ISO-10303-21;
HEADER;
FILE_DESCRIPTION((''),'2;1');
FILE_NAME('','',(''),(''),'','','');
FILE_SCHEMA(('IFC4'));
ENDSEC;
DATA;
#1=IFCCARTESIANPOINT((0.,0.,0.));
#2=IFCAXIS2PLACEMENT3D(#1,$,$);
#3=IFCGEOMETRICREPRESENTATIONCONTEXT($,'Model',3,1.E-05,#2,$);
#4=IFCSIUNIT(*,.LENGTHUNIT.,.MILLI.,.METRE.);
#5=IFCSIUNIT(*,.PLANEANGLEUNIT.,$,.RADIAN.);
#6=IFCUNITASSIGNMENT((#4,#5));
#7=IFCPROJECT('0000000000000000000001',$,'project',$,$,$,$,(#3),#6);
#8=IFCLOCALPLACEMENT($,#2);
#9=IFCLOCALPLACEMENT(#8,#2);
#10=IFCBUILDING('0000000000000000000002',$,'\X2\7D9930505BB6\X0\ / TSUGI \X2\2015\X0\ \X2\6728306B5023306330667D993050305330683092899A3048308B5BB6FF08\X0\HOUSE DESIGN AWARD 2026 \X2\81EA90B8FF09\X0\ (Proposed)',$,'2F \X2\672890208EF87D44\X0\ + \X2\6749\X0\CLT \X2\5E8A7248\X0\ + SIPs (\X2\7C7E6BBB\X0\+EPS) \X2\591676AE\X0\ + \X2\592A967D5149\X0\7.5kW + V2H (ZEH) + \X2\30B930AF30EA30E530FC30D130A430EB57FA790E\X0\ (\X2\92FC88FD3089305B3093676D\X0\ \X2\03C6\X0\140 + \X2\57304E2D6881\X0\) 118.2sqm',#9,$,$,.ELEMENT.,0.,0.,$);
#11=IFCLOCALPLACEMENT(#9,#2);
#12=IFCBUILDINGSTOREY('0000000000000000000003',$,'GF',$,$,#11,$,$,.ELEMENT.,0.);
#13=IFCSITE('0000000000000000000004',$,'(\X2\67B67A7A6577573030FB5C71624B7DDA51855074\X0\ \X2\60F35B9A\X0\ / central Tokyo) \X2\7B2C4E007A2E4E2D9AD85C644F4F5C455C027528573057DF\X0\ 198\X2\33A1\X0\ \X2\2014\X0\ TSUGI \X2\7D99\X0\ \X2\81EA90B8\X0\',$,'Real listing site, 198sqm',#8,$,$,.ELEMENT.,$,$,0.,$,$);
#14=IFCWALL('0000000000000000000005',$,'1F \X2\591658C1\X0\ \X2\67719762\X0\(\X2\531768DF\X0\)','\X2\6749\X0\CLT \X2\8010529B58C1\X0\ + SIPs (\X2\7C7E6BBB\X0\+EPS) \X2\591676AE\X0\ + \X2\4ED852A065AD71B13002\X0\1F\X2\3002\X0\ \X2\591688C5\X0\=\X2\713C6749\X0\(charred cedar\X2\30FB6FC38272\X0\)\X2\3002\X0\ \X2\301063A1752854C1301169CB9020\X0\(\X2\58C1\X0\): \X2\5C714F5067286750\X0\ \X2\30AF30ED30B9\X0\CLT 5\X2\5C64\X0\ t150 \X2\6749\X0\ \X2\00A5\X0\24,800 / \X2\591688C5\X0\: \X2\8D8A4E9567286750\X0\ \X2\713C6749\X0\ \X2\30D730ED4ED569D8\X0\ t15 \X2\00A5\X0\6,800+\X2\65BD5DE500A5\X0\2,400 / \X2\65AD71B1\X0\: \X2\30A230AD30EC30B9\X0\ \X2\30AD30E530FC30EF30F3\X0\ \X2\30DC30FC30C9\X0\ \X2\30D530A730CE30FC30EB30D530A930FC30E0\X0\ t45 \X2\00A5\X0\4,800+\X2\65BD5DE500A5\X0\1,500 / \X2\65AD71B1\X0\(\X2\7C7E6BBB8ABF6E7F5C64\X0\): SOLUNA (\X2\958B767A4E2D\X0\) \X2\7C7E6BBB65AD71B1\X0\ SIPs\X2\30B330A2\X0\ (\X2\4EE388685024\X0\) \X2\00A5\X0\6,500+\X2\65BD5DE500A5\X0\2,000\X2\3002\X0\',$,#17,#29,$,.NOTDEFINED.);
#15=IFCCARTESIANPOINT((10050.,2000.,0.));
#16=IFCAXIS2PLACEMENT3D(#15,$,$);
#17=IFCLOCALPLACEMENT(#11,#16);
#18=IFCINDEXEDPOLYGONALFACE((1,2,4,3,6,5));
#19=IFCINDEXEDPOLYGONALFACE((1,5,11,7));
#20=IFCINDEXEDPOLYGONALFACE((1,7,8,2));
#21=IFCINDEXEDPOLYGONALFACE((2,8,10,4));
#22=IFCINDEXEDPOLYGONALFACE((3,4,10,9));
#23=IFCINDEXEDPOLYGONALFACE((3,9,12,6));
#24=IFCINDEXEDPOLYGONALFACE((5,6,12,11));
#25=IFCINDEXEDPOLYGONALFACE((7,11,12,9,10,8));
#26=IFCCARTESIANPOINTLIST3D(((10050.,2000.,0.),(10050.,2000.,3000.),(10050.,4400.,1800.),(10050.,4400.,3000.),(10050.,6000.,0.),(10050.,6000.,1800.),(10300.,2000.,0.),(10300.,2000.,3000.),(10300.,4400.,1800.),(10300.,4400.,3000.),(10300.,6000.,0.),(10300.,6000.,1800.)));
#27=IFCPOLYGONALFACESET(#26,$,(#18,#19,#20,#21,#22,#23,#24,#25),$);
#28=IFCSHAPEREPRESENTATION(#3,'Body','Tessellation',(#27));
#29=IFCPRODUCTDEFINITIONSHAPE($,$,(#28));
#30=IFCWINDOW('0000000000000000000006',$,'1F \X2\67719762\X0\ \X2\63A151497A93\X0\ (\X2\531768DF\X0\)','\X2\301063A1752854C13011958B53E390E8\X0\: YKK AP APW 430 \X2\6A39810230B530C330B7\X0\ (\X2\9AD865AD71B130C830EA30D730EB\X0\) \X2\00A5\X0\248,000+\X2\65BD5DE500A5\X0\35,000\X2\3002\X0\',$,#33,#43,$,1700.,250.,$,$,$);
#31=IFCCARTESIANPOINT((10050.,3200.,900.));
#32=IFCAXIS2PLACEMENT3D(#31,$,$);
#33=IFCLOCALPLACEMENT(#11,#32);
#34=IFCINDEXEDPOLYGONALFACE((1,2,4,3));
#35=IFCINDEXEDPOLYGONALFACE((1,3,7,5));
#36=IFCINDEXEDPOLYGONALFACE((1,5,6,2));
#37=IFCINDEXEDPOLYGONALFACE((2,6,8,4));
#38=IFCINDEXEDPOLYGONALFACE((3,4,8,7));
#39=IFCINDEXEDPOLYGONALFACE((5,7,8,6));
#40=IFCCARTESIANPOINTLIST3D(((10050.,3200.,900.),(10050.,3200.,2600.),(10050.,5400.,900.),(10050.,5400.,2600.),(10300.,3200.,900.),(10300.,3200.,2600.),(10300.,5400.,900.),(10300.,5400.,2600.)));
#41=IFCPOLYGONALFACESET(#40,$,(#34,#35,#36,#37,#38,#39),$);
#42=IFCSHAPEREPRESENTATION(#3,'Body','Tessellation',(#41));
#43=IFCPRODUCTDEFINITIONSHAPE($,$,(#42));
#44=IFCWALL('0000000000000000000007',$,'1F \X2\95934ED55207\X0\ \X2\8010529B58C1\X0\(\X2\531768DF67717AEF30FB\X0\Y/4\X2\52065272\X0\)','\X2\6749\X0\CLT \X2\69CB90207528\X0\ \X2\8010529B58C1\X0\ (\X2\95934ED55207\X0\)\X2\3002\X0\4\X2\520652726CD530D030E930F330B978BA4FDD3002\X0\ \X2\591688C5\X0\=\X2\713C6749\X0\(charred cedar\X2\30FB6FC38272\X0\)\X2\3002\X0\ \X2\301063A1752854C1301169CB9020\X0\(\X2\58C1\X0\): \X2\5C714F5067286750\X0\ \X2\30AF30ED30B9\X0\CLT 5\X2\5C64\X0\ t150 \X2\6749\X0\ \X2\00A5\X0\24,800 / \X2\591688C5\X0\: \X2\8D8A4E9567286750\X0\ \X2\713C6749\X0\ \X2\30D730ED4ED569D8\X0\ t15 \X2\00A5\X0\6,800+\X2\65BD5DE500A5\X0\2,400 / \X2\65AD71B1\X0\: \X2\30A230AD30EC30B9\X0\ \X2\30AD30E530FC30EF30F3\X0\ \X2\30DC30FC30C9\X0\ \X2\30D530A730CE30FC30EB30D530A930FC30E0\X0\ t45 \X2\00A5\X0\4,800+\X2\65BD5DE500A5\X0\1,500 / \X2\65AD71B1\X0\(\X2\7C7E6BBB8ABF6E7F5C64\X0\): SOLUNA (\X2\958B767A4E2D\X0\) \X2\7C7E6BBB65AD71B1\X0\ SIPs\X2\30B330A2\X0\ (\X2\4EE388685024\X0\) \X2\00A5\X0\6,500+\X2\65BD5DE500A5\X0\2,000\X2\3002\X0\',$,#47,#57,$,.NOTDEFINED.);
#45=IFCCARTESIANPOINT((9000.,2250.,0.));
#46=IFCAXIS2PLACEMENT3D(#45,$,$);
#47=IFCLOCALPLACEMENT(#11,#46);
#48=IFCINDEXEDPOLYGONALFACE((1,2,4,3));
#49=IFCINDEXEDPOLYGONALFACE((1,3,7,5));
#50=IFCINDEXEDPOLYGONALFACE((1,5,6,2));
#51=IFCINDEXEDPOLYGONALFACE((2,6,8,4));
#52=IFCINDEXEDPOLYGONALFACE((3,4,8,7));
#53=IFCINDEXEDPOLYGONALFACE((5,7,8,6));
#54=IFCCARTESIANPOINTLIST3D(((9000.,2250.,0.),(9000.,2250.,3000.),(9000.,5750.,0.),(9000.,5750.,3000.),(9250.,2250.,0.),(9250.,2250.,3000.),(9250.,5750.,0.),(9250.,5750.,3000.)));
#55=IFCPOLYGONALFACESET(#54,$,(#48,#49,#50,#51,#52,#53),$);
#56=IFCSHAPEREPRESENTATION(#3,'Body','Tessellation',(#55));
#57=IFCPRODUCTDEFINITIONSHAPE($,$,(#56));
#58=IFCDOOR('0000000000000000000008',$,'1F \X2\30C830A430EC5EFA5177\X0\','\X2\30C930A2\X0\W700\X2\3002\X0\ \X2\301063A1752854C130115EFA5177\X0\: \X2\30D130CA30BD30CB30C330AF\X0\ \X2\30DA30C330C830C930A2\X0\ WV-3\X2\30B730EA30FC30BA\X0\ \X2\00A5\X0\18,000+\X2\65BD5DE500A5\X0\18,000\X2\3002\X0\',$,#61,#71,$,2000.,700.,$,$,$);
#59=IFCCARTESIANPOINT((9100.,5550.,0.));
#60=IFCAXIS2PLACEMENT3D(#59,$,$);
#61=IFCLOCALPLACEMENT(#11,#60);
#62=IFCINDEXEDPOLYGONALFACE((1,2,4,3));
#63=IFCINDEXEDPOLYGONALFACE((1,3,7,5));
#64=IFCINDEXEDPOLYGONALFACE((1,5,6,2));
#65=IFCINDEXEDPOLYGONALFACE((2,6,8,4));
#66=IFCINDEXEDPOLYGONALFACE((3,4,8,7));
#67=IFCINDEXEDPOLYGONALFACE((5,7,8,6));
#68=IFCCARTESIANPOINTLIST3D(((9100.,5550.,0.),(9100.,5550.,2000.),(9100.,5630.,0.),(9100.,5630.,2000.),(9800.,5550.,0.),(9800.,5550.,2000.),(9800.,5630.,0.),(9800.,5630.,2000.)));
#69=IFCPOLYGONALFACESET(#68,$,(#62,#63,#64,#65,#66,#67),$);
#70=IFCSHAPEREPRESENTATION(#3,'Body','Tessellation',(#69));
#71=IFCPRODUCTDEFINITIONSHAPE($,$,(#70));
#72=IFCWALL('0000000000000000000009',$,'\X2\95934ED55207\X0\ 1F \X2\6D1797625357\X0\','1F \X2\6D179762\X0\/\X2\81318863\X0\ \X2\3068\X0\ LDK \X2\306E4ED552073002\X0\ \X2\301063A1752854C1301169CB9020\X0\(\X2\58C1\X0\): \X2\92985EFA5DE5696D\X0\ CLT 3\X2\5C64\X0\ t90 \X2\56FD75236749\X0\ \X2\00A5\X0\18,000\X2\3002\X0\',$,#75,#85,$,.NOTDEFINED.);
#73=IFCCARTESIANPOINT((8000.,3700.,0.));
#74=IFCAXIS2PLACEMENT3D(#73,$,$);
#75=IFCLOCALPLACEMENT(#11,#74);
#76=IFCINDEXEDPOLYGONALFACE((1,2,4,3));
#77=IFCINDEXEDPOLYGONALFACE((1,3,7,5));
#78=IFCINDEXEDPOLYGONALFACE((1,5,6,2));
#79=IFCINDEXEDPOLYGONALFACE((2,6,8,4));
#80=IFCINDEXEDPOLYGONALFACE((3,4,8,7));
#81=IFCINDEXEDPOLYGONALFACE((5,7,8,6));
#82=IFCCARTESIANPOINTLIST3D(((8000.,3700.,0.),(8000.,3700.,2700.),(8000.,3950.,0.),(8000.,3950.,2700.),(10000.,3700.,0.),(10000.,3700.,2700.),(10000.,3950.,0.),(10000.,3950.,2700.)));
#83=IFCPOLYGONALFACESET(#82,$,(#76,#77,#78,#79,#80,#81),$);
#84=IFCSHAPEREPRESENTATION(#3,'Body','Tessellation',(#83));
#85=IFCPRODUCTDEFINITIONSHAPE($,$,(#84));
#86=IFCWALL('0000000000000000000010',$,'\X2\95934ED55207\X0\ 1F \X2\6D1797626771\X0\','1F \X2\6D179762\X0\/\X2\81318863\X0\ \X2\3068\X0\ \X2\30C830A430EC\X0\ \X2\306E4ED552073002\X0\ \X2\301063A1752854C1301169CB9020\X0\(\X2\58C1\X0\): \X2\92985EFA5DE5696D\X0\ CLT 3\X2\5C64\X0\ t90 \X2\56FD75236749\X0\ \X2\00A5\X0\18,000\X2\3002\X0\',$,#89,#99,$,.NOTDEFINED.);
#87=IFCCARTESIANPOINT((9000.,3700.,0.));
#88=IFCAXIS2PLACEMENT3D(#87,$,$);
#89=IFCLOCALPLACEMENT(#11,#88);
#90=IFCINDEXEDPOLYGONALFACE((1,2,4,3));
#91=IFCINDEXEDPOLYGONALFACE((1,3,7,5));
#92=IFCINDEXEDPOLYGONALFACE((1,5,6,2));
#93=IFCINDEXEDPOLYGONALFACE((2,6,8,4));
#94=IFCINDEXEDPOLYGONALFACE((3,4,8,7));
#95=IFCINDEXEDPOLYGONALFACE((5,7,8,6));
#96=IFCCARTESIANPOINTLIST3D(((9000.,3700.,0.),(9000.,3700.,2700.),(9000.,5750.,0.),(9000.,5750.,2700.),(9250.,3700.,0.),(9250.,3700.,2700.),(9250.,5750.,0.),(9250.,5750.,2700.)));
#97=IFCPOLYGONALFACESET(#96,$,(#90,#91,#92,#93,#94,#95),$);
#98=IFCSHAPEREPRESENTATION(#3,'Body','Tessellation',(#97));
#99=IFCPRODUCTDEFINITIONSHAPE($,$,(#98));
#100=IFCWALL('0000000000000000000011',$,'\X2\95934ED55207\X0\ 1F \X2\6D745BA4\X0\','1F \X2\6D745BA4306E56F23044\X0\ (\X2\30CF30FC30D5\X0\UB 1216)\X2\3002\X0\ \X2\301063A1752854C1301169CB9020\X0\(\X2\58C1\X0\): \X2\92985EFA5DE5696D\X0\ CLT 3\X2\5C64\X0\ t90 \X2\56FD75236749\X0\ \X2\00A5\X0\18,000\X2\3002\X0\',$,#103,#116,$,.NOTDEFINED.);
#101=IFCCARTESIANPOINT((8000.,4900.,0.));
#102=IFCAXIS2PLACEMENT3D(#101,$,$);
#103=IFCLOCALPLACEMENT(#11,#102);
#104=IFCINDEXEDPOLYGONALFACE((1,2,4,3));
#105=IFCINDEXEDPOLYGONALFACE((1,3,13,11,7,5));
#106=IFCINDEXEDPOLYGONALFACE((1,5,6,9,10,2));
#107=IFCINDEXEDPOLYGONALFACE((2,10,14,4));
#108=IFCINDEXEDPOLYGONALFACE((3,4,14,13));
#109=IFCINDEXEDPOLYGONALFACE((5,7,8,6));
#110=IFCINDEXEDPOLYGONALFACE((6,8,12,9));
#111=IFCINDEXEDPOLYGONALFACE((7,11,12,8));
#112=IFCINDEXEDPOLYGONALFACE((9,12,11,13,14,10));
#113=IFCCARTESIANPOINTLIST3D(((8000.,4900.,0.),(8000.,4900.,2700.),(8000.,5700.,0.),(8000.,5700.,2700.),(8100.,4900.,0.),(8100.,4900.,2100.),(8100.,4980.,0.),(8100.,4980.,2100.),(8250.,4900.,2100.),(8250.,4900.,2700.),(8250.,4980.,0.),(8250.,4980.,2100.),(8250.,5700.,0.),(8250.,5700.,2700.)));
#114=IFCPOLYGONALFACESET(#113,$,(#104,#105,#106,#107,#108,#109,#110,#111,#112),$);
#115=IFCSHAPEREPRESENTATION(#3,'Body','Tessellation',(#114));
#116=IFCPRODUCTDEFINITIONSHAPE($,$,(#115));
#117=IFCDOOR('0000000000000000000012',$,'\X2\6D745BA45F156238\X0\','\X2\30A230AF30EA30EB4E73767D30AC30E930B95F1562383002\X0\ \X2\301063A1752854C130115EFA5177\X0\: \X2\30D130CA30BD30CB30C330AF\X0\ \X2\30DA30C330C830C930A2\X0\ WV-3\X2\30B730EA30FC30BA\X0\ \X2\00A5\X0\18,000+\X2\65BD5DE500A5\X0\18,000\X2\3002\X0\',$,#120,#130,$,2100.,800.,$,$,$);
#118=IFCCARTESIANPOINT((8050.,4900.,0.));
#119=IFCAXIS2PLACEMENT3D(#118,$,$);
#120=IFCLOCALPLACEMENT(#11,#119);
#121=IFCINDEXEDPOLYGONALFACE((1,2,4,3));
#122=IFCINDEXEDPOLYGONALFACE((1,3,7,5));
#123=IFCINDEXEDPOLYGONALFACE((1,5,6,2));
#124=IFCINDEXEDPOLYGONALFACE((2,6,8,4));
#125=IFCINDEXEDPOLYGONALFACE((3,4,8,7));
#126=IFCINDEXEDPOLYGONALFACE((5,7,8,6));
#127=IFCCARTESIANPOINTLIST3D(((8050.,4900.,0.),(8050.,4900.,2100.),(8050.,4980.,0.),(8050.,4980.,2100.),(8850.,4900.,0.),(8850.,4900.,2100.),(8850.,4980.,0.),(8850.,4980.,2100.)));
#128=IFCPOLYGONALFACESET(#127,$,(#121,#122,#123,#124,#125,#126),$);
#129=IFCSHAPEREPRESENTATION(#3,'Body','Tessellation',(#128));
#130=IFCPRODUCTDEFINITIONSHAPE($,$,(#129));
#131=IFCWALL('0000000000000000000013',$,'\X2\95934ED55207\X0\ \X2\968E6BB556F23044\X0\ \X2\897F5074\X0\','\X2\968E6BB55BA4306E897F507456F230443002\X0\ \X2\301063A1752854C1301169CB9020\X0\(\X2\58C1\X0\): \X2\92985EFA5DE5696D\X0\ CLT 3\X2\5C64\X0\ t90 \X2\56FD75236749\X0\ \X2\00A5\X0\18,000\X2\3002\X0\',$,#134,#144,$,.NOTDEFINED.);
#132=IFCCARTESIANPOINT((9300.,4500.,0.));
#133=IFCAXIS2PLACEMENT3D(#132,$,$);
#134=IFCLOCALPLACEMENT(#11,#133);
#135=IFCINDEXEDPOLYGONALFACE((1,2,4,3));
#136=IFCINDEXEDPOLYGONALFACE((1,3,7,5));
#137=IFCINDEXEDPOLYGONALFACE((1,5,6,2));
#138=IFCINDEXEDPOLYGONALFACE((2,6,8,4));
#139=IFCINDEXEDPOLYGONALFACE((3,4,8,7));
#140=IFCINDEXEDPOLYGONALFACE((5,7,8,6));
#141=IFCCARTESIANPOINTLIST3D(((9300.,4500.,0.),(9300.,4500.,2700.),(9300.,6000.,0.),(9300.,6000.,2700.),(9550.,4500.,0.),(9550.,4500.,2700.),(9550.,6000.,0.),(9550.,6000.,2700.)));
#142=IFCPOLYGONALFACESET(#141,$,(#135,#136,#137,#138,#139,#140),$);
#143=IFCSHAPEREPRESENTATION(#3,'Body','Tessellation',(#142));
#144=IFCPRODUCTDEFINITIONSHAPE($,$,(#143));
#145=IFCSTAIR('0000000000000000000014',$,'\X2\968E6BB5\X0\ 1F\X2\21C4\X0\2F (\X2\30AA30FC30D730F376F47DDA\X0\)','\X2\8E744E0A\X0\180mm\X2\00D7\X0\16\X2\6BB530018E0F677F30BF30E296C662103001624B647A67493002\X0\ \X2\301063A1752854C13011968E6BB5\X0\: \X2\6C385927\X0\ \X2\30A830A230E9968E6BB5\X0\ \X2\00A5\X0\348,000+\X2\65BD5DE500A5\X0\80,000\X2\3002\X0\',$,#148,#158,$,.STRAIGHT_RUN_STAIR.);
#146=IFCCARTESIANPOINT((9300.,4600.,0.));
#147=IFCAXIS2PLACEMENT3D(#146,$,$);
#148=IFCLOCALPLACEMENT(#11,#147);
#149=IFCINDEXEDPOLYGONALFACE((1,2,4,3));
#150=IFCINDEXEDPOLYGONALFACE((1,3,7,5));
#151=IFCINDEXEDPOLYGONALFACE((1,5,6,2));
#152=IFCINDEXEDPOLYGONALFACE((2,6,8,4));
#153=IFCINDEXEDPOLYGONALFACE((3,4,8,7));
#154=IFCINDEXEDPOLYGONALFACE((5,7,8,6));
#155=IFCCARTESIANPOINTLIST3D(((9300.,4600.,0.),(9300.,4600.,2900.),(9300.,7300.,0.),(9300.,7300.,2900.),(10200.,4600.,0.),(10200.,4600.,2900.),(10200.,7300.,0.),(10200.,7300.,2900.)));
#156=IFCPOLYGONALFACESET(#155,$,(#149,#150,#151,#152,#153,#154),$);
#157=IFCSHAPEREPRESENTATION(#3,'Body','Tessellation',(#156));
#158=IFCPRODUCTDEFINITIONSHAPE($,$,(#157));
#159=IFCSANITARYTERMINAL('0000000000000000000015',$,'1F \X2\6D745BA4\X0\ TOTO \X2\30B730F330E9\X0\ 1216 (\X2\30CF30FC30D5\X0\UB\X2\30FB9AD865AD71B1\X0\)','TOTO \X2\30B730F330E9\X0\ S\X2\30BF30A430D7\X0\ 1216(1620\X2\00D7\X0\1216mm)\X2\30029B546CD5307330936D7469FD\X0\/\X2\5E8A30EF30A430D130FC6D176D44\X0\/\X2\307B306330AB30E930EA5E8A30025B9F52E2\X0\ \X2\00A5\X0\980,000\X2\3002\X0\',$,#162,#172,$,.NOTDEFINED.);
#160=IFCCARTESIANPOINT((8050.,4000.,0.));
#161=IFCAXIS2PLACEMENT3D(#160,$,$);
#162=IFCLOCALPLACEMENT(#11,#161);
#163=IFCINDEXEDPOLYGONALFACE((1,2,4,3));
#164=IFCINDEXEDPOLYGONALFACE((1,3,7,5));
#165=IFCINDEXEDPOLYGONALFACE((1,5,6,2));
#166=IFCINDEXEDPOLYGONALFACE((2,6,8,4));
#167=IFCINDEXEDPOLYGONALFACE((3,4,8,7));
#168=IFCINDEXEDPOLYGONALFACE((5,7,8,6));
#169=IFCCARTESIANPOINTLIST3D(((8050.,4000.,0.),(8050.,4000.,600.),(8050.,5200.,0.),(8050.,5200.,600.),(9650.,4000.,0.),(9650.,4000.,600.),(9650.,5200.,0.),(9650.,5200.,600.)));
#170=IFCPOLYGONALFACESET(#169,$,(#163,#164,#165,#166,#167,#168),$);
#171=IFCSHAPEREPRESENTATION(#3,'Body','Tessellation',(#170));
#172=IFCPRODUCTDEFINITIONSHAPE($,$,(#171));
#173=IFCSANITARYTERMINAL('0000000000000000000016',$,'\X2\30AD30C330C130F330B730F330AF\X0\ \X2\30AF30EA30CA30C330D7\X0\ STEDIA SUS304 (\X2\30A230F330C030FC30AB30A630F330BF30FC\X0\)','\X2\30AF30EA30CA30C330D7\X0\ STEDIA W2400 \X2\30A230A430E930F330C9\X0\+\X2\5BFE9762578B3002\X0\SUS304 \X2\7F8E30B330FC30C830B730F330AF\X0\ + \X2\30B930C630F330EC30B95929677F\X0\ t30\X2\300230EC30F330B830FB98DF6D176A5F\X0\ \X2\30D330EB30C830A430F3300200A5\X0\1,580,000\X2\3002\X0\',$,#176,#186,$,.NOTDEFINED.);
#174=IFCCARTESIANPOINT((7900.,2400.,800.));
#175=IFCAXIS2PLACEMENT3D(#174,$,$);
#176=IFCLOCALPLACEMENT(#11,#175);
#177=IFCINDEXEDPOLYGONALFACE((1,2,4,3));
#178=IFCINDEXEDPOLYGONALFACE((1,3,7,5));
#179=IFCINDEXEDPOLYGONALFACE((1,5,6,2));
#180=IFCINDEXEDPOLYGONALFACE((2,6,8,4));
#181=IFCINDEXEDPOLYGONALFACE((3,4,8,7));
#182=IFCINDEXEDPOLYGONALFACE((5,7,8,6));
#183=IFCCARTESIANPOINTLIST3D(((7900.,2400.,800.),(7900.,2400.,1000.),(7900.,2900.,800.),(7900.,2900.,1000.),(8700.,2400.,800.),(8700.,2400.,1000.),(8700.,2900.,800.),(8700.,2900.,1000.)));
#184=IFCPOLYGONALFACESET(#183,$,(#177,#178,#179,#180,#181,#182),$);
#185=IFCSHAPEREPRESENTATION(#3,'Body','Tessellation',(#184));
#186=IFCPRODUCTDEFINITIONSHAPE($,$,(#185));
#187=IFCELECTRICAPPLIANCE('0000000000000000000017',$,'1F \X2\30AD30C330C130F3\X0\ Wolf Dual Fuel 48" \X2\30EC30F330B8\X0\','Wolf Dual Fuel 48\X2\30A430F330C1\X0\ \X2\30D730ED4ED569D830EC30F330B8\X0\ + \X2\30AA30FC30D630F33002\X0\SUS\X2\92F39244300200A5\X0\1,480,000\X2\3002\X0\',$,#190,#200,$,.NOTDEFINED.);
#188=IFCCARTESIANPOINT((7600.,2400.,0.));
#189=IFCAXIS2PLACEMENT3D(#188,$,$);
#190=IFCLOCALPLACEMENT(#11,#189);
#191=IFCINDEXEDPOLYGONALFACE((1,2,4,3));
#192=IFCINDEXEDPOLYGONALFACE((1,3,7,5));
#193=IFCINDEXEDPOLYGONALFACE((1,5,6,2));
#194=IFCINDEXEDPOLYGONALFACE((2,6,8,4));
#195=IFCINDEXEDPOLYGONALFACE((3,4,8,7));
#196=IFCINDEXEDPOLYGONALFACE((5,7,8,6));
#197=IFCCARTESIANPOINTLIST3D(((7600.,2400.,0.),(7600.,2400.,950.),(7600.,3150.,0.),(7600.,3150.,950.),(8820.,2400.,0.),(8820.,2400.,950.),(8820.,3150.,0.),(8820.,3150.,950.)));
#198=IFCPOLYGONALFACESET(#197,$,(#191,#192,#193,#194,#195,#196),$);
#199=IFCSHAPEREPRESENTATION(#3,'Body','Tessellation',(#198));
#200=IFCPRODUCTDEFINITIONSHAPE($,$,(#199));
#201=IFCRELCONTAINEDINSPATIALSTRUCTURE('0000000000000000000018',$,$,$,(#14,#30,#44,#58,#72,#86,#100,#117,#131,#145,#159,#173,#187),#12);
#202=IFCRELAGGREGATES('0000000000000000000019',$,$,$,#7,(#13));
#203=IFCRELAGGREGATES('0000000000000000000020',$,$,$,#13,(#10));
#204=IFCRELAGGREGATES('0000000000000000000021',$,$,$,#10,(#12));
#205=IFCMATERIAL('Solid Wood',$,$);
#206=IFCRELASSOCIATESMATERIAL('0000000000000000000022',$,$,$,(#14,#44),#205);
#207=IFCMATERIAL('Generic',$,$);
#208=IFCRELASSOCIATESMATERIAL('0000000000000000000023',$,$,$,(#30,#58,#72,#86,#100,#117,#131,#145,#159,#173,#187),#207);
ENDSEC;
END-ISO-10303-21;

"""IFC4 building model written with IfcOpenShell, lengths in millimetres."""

from ifc_helpers import new_model, si_unit, frame, frame_2d, origin, place, context, project, spatial, rectangle, extrude, material, element, fill, save


model = new_model("IFC4")

# Units and contexts
model_context = context("Model", 3, precision=1e-05, world=origin())
ifc_project = project(units=[si_unit("LENGTHUNIT", "METRE", prefix="MILLI"), si_unit("PLANEANGLEUNIT", "RADIAN")], contexts=[model_context])

# Site, building, storey
site_placement = place(None, origin())
site = spatial("IfcSite", under=ifc_project, at=site_placement, Name="(架空敷地・山手線内側 想定 / central Tokyo) 第一種中高層住居専用地域 198㎡ — TSUGI 継 自邸", ObjectType="Real listing site, 198sqm", CompositionType="ELEMENT", RefElevation=0.0)
building_placement = place(site_placement, origin())
building = spatial("IfcBuilding", under=site, at=building_placement, Name="継ぐ家 / TSUGI ― 木に倣って継ぐことを覚える家（HOUSE DESIGN AWARD 2026 自邸） (Proposed)", ObjectType="2F 木造軸組 + 杉CLT 床版 + SIPs (籾殻+EPS) 外皮 + 太陽光7.5kW + V2H (ZEH) + スクリューパイル基礎 (鋼製らせん杭 φ140 + 地中梁) 118.2sqm", CompositionType="ELEMENT", ElevationOfRefHeight=0.0, ElevationOfTerrain=0.0)
storey_placement = place(building_placement, origin())
storey = spatial("IfcBuildingStorey", under=building, at=storey_placement, Name="GF", CompositionType="ELEMENT", Elevation=0.0)

# Shared definitions
ifc_material_1 = material(Name="Generic")

# Wall, opening, window
ifc_material_2 = material(Name="Solid Wood")
wall_1_placement = place(storey_placement, frame((10050.0, 2000.0, 0.0)))
wall_1 = element("IfcWall", 1, at=wall_1_placement, inside=storey, material=ifc_material_2, Name="1F 外壁 東面(北棟)", Description="杉CLT 耐力壁 + SIPs (籾殻+EPS) 外皮 + 付加断熱。1F。 外装=焼杉(charred cedar・濃色)。 【採用品】構造(壁): 山佐木材 クロスCLT 5層 t150 杉 ¥24,800 / 外装: 越井木材 焼杉 プロ仕様 t15 ¥6,800+施工¥2,400 / 断熱: アキレス キューワン ボード フェノールフォーム t45 ¥4,800+施工¥1,500 / 断熱(籾殻調湿層): SOLUNA (開発中) 籾殻断熱 SIPsコア (代表値) ¥6,500+施工¥2,000。", PredefinedType="NOTDEFINED", context=model_context, shape_type="SweptSolid", body=[
    extrude(rectangle(XDim=250.0, YDim=4000.0, at=frame_2d((125.0, 2000.0))), frame((10050.0, 2000.0, 0.0)), (0.0, 0.0, 1.0), 3000.0),
])
opening_1_placement = place(storey_placement, frame((10050.0, 3200.0, 900.0)))
opening_1 = element("IfcOpeningElement", 2, at=opening_1_placement, cuts=wall_1, PredefinedType="NOTDEFINED", context=model_context, shape_type="SweptSolid", body=[
    extrude(rectangle(XDim=250.0, YDim=2200.0, at=frame_2d((125.0, 1100.0))), frame((10050.0, 3200.0, 900.0)), (0.0, 0.0, 1.0), 1700.0),
])
window_placement = place(storey_placement, frame((10050.0, 3200.0, 900.0)))
window = element("IfcWindow", 3, at=window_placement, inside=storey, material=ifc_material_1, Name="1F 東面 採光窓 (北棟)", Description="【採用品】開口部: YKK AP APW 430 樹脂サッシ (高断熱トリプル) ¥248,000+施工¥35,000。", OverallHeight=1700.0, OverallWidth=250.0, context=model_context, shape_type="SweptSolid", body=[
    extrude(rectangle(XDim=250.0, YDim=2200.0, at=frame_2d((125.0, 1100.0))), frame((10050.0, 3200.0, 900.0)), (0.0, 0.0, 1.0), 1700.0),
])
fill(opening_1, window)

# Wall, opening, door
wall_2_placement = place(storey_placement, frame((9000.0, 2250.0, 0.0)))
wall_2 = element("IfcWall", 4, at=wall_2_placement, inside=storey, material=ifc_material_2, Name="1F 間仕切 耐力壁(北棟東端・Y/4分割)", Description="杉CLT 構造用 耐力壁 (間仕切)。4分割法バランス確保。 外装=焼杉(charred cedar・濃色)。 【採用品】構造(壁): 山佐木材 クロスCLT 5層 t150 杉 ¥24,800 / 外装: 越井木材 焼杉 プロ仕様 t15 ¥6,800+施工¥2,400 / 断熱: アキレス キューワン ボード フェノールフォーム t45 ¥4,800+施工¥1,500 / 断熱(籾殻調湿層): SOLUNA (開発中) 籾殻断熱 SIPsコア (代表値) ¥6,500+施工¥2,000。", PredefinedType="NOTDEFINED", context=model_context, shape_type="SweptSolid", body=[
    extrude(rectangle(XDim=250.0, YDim=3500.0, at=frame_2d((125.0, 1750.0))), frame((9000.0, 2250.0, 0.0)), (0.0, 0.0, 1.0), 3000.0),
])
opening_2_placement = place(storey_placement, frame((9100.0, 5550.0, 0.0)))
opening_2 = element("IfcOpeningElement", 5, at=opening_2_placement, cuts=wall_2, PredefinedType="NOTDEFINED", context=model_context, shape_type="SweptSolid", body=[
    extrude(rectangle(XDim=700.0, YDim=80.0, at=frame_2d((350.0, 40.0))), frame((9100.0, 5550.0, 0.0)), (0.0, 0.0, 1.0), 2000.0),
])
door_1_placement = place(storey_placement, frame((9100.0, 5550.0, 0.0)))
door_1 = element("IfcDoor", 6, at=door_1_placement, inside=storey, material=ifc_material_1, Name="1F トイレ建具", Description="ドアW700。 【採用品】建具: パナソニック ペットドア WV-3シリーズ ¥18,000+施工¥18,000。", OverallHeight=2000.0, OverallWidth=700.0, context=model_context, shape_type="SweptSolid", body=[
    extrude(rectangle(XDim=700.0, YDim=80.0, at=frame_2d((350.0, 40.0))), frame((9100.0, 5550.0, 0.0)), (0.0, 0.0, 1.0), 2000.0),
])
fill(opening_2, door_1)

# Walls
wall_3_placement = place(storey_placement, frame((8000.0, 3700.0, 0.0)))
element("IfcWall", 7, at=wall_3_placement, inside=storey, material=ifc_material_1, Name="間仕切 1F 洗面南", Description="1F 洗面/脱衣 と LDK の仕切。 【採用品】構造(壁): 銘建工業 CLT 3層 t90 国産杉 ¥18,000。", PredefinedType="NOTDEFINED", context=model_context, shape_type="SweptSolid", body=[
    extrude(rectangle(XDim=2000.0, YDim=250.0, at=frame_2d((1000.0, 125.0))), frame((8000.0, 3700.0, 0.0)), (0.0, 0.0, 1.0), 2700.0),
])
wall_4_placement = place(storey_placement, frame((9000.0, 3700.0, 0.0)))
element("IfcWall", 8, at=wall_4_placement, inside=storey, material=ifc_material_1, Name="間仕切 1F 洗面東", Description="1F 洗面/脱衣 と トイレ の仕切。 【採用品】構造(壁): 銘建工業 CLT 3層 t90 国産杉 ¥18,000。", PredefinedType="NOTDEFINED", context=model_context, shape_type="SweptSolid", body=[
    extrude(rectangle(XDim=250.0, YDim=2050.0, at=frame_2d((125.0, 1025.0))), frame((9000.0, 3700.0, 0.0)), (0.0, 0.0, 1.0), 2700.0),
])

# Wall, opening, door
wall_5_placement = place(storey_placement, frame((8000.0, 4900.0, 0.0)))
wall_5 = element("IfcWall", 9, at=wall_5_placement, inside=storey, material=ifc_material_1, Name="間仕切 1F 浴室", Description="1F 浴室の囲い (ハーフUB 1216)。 【採用品】構造(壁): 銘建工業 CLT 3層 t90 国産杉 ¥18,000。", PredefinedType="NOTDEFINED", context=model_context, shape_type="SweptSolid", body=[
    extrude(rectangle(XDim=250.0, YDim=800.0, at=frame_2d((125.0, 400.0))), frame((8000.0, 4900.0, 0.0)), (0.0, 0.0, 1.0), 2700.0),
])
opening_3_placement = place(storey_placement, frame((8050.0, 4900.0, 0.0)))
opening_3 = element("IfcOpeningElement", 10, at=opening_3_placement, cuts=wall_5, PredefinedType="NOTDEFINED", context=model_context, shape_type="SweptSolid", body=[
    extrude(rectangle(XDim=800.0, YDim=80.0, at=frame_2d((400.0, 40.0))), frame((8050.0, 4900.0, 0.0)), (0.0, 0.0, 1.0), 2100.0),
])
door_2_placement = place(storey_placement, frame((8050.0, 4900.0, 0.0)))
door_2 = element("IfcDoor", 11, at=door_2_placement, inside=storey, material=ifc_material_1, Name="浴室引戸", Description="アクリル乳白ガラス引戸。 【採用品】建具: パナソニック ペットドア WV-3シリーズ ¥18,000+施工¥18,000。", OverallHeight=2100.0, OverallWidth=800.0, context=model_context, shape_type="SweptSolid", body=[
    extrude(rectangle(XDim=800.0, YDim=80.0, at=frame_2d((400.0, 40.0))), frame((8050.0, 4900.0, 0.0)), (0.0, 0.0, 1.0), 2100.0),
])
fill(opening_3, door_2)

# Wall
wall_6_placement = place(storey_placement, frame((9300.0, 4500.0, 0.0)))
element("IfcWall", 12, at=wall_6_placement, inside=storey, material=ifc_material_1, Name="間仕切 階段囲い 西側", Description="階段室の西側囲い。 【採用品】構造(壁): 銘建工業 CLT 3層 t90 国産杉 ¥18,000。", PredefinedType="NOTDEFINED", context=model_context, shape_type="SweptSolid", body=[
    extrude(rectangle(XDim=250.0, YDim=1500.0, at=frame_2d((125.0, 750.0))), frame((9300.0, 4500.0, 0.0)), (0.0, 0.0, 1.0), 2700.0),
])

# Stair
stair_placement = place(storey_placement, frame((9300.0, 4600.0, 0.0)))
element("IfcStair", 13, at=stair_placement, inside=storey, material=ifc_material_1, Name="階段 1F⇄2F (オープン直線)", Description="蹴上180mm×16段、踏板タモ集成、手摺杉。 【採用品】階段: 永大 エアラ階段 ¥348,000+施工¥80,000。", PredefinedType="STRAIGHT_RUN_STAIR", context=model_context, shape_type="SweptSolid", body=[
    extrude(rectangle(XDim=900.0, YDim=2700.0, at=frame_2d((450.0, 1350.0))), frame((9300.0, 4600.0, 0.0)), (0.0, 0.0, 1.0), 2900.0),
])

# Sanitary terminals
sanitary_terminal_1_placement = place(storey_placement, frame((8050.0, 4000.0, 0.0)))
element("IfcSanitaryTerminal", 14, at=sanitary_terminal_1_placement, inside=storey, material=ifc_material_1, Name="1F 浴室 TOTO シンラ 1216 (ハーフUB・高断熱)", Description="TOTO シンラ Sタイプ 1216(1620×1216mm)。魔法びん浴槽/床ワイパー洗浄/ほっカラリ床。実勢 ¥980,000。", PredefinedType="NOTDEFINED", context=model_context, shape_type="SweptSolid", body=[
    extrude(rectangle(XDim=1600.0, YDim=1200.0, at=frame_2d((800.0, 600.0))), frame((8050.0, 4000.0, 0.0)), (0.0, 0.0, 1.0), 600.0),
])
sanitary_terminal_2_placement = place(storey_placement, frame((7900.0, 2400.0, 800.0)))
element("IfcSanitaryTerminal", 15, at=sanitary_terminal_2_placement, inside=storey, material=ifc_material_1, Name="キッチンシンク クリナップ STEDIA SUS304 (アンダーカウンター)", Description="クリナップ STEDIA W2400 アイランド+対面型。SUS304 美コートシンク + ステンレス天板 t30。レンジ・食洗機 ビルトイン。¥1,580,000。", PredefinedType="NOTDEFINED", context=model_context, shape_type="SweptSolid", body=[
    extrude(rectangle(XDim=800.0, YDim=500.0, at=frame_2d((400.0, 250.0))), frame((7900.0, 2400.0, 800.0)), (0.0, 0.0, 1.0), 200.0),
])

# Electric appliance
electric_appliance_1_placement = place(storey_placement, frame((7600.0, 2400.0, 0.0)))
element("IfcElectricAppliance", 16, at=electric_appliance_1_placement, inside=storey, material=ifc_material_1, Name="1F キッチン Wolf Dual Fuel 48\" レンジ", Description="Wolf Dual Fuel 48インチ プロ仕様レンジ + オーブン。SUS鋳鉄。¥1,480,000。", PredefinedType="NOTDEFINED", context=model_context, shape_type="SweptSolid", body=[
    extrude(rectangle(XDim=1220.0, YDim=750.0, at=frame_2d((610.0, 375.0))), frame((7600.0, 2400.0, 0.0)), (0.0, 0.0, 1.0), 950.0),
])

save(model, "model.ifc")
